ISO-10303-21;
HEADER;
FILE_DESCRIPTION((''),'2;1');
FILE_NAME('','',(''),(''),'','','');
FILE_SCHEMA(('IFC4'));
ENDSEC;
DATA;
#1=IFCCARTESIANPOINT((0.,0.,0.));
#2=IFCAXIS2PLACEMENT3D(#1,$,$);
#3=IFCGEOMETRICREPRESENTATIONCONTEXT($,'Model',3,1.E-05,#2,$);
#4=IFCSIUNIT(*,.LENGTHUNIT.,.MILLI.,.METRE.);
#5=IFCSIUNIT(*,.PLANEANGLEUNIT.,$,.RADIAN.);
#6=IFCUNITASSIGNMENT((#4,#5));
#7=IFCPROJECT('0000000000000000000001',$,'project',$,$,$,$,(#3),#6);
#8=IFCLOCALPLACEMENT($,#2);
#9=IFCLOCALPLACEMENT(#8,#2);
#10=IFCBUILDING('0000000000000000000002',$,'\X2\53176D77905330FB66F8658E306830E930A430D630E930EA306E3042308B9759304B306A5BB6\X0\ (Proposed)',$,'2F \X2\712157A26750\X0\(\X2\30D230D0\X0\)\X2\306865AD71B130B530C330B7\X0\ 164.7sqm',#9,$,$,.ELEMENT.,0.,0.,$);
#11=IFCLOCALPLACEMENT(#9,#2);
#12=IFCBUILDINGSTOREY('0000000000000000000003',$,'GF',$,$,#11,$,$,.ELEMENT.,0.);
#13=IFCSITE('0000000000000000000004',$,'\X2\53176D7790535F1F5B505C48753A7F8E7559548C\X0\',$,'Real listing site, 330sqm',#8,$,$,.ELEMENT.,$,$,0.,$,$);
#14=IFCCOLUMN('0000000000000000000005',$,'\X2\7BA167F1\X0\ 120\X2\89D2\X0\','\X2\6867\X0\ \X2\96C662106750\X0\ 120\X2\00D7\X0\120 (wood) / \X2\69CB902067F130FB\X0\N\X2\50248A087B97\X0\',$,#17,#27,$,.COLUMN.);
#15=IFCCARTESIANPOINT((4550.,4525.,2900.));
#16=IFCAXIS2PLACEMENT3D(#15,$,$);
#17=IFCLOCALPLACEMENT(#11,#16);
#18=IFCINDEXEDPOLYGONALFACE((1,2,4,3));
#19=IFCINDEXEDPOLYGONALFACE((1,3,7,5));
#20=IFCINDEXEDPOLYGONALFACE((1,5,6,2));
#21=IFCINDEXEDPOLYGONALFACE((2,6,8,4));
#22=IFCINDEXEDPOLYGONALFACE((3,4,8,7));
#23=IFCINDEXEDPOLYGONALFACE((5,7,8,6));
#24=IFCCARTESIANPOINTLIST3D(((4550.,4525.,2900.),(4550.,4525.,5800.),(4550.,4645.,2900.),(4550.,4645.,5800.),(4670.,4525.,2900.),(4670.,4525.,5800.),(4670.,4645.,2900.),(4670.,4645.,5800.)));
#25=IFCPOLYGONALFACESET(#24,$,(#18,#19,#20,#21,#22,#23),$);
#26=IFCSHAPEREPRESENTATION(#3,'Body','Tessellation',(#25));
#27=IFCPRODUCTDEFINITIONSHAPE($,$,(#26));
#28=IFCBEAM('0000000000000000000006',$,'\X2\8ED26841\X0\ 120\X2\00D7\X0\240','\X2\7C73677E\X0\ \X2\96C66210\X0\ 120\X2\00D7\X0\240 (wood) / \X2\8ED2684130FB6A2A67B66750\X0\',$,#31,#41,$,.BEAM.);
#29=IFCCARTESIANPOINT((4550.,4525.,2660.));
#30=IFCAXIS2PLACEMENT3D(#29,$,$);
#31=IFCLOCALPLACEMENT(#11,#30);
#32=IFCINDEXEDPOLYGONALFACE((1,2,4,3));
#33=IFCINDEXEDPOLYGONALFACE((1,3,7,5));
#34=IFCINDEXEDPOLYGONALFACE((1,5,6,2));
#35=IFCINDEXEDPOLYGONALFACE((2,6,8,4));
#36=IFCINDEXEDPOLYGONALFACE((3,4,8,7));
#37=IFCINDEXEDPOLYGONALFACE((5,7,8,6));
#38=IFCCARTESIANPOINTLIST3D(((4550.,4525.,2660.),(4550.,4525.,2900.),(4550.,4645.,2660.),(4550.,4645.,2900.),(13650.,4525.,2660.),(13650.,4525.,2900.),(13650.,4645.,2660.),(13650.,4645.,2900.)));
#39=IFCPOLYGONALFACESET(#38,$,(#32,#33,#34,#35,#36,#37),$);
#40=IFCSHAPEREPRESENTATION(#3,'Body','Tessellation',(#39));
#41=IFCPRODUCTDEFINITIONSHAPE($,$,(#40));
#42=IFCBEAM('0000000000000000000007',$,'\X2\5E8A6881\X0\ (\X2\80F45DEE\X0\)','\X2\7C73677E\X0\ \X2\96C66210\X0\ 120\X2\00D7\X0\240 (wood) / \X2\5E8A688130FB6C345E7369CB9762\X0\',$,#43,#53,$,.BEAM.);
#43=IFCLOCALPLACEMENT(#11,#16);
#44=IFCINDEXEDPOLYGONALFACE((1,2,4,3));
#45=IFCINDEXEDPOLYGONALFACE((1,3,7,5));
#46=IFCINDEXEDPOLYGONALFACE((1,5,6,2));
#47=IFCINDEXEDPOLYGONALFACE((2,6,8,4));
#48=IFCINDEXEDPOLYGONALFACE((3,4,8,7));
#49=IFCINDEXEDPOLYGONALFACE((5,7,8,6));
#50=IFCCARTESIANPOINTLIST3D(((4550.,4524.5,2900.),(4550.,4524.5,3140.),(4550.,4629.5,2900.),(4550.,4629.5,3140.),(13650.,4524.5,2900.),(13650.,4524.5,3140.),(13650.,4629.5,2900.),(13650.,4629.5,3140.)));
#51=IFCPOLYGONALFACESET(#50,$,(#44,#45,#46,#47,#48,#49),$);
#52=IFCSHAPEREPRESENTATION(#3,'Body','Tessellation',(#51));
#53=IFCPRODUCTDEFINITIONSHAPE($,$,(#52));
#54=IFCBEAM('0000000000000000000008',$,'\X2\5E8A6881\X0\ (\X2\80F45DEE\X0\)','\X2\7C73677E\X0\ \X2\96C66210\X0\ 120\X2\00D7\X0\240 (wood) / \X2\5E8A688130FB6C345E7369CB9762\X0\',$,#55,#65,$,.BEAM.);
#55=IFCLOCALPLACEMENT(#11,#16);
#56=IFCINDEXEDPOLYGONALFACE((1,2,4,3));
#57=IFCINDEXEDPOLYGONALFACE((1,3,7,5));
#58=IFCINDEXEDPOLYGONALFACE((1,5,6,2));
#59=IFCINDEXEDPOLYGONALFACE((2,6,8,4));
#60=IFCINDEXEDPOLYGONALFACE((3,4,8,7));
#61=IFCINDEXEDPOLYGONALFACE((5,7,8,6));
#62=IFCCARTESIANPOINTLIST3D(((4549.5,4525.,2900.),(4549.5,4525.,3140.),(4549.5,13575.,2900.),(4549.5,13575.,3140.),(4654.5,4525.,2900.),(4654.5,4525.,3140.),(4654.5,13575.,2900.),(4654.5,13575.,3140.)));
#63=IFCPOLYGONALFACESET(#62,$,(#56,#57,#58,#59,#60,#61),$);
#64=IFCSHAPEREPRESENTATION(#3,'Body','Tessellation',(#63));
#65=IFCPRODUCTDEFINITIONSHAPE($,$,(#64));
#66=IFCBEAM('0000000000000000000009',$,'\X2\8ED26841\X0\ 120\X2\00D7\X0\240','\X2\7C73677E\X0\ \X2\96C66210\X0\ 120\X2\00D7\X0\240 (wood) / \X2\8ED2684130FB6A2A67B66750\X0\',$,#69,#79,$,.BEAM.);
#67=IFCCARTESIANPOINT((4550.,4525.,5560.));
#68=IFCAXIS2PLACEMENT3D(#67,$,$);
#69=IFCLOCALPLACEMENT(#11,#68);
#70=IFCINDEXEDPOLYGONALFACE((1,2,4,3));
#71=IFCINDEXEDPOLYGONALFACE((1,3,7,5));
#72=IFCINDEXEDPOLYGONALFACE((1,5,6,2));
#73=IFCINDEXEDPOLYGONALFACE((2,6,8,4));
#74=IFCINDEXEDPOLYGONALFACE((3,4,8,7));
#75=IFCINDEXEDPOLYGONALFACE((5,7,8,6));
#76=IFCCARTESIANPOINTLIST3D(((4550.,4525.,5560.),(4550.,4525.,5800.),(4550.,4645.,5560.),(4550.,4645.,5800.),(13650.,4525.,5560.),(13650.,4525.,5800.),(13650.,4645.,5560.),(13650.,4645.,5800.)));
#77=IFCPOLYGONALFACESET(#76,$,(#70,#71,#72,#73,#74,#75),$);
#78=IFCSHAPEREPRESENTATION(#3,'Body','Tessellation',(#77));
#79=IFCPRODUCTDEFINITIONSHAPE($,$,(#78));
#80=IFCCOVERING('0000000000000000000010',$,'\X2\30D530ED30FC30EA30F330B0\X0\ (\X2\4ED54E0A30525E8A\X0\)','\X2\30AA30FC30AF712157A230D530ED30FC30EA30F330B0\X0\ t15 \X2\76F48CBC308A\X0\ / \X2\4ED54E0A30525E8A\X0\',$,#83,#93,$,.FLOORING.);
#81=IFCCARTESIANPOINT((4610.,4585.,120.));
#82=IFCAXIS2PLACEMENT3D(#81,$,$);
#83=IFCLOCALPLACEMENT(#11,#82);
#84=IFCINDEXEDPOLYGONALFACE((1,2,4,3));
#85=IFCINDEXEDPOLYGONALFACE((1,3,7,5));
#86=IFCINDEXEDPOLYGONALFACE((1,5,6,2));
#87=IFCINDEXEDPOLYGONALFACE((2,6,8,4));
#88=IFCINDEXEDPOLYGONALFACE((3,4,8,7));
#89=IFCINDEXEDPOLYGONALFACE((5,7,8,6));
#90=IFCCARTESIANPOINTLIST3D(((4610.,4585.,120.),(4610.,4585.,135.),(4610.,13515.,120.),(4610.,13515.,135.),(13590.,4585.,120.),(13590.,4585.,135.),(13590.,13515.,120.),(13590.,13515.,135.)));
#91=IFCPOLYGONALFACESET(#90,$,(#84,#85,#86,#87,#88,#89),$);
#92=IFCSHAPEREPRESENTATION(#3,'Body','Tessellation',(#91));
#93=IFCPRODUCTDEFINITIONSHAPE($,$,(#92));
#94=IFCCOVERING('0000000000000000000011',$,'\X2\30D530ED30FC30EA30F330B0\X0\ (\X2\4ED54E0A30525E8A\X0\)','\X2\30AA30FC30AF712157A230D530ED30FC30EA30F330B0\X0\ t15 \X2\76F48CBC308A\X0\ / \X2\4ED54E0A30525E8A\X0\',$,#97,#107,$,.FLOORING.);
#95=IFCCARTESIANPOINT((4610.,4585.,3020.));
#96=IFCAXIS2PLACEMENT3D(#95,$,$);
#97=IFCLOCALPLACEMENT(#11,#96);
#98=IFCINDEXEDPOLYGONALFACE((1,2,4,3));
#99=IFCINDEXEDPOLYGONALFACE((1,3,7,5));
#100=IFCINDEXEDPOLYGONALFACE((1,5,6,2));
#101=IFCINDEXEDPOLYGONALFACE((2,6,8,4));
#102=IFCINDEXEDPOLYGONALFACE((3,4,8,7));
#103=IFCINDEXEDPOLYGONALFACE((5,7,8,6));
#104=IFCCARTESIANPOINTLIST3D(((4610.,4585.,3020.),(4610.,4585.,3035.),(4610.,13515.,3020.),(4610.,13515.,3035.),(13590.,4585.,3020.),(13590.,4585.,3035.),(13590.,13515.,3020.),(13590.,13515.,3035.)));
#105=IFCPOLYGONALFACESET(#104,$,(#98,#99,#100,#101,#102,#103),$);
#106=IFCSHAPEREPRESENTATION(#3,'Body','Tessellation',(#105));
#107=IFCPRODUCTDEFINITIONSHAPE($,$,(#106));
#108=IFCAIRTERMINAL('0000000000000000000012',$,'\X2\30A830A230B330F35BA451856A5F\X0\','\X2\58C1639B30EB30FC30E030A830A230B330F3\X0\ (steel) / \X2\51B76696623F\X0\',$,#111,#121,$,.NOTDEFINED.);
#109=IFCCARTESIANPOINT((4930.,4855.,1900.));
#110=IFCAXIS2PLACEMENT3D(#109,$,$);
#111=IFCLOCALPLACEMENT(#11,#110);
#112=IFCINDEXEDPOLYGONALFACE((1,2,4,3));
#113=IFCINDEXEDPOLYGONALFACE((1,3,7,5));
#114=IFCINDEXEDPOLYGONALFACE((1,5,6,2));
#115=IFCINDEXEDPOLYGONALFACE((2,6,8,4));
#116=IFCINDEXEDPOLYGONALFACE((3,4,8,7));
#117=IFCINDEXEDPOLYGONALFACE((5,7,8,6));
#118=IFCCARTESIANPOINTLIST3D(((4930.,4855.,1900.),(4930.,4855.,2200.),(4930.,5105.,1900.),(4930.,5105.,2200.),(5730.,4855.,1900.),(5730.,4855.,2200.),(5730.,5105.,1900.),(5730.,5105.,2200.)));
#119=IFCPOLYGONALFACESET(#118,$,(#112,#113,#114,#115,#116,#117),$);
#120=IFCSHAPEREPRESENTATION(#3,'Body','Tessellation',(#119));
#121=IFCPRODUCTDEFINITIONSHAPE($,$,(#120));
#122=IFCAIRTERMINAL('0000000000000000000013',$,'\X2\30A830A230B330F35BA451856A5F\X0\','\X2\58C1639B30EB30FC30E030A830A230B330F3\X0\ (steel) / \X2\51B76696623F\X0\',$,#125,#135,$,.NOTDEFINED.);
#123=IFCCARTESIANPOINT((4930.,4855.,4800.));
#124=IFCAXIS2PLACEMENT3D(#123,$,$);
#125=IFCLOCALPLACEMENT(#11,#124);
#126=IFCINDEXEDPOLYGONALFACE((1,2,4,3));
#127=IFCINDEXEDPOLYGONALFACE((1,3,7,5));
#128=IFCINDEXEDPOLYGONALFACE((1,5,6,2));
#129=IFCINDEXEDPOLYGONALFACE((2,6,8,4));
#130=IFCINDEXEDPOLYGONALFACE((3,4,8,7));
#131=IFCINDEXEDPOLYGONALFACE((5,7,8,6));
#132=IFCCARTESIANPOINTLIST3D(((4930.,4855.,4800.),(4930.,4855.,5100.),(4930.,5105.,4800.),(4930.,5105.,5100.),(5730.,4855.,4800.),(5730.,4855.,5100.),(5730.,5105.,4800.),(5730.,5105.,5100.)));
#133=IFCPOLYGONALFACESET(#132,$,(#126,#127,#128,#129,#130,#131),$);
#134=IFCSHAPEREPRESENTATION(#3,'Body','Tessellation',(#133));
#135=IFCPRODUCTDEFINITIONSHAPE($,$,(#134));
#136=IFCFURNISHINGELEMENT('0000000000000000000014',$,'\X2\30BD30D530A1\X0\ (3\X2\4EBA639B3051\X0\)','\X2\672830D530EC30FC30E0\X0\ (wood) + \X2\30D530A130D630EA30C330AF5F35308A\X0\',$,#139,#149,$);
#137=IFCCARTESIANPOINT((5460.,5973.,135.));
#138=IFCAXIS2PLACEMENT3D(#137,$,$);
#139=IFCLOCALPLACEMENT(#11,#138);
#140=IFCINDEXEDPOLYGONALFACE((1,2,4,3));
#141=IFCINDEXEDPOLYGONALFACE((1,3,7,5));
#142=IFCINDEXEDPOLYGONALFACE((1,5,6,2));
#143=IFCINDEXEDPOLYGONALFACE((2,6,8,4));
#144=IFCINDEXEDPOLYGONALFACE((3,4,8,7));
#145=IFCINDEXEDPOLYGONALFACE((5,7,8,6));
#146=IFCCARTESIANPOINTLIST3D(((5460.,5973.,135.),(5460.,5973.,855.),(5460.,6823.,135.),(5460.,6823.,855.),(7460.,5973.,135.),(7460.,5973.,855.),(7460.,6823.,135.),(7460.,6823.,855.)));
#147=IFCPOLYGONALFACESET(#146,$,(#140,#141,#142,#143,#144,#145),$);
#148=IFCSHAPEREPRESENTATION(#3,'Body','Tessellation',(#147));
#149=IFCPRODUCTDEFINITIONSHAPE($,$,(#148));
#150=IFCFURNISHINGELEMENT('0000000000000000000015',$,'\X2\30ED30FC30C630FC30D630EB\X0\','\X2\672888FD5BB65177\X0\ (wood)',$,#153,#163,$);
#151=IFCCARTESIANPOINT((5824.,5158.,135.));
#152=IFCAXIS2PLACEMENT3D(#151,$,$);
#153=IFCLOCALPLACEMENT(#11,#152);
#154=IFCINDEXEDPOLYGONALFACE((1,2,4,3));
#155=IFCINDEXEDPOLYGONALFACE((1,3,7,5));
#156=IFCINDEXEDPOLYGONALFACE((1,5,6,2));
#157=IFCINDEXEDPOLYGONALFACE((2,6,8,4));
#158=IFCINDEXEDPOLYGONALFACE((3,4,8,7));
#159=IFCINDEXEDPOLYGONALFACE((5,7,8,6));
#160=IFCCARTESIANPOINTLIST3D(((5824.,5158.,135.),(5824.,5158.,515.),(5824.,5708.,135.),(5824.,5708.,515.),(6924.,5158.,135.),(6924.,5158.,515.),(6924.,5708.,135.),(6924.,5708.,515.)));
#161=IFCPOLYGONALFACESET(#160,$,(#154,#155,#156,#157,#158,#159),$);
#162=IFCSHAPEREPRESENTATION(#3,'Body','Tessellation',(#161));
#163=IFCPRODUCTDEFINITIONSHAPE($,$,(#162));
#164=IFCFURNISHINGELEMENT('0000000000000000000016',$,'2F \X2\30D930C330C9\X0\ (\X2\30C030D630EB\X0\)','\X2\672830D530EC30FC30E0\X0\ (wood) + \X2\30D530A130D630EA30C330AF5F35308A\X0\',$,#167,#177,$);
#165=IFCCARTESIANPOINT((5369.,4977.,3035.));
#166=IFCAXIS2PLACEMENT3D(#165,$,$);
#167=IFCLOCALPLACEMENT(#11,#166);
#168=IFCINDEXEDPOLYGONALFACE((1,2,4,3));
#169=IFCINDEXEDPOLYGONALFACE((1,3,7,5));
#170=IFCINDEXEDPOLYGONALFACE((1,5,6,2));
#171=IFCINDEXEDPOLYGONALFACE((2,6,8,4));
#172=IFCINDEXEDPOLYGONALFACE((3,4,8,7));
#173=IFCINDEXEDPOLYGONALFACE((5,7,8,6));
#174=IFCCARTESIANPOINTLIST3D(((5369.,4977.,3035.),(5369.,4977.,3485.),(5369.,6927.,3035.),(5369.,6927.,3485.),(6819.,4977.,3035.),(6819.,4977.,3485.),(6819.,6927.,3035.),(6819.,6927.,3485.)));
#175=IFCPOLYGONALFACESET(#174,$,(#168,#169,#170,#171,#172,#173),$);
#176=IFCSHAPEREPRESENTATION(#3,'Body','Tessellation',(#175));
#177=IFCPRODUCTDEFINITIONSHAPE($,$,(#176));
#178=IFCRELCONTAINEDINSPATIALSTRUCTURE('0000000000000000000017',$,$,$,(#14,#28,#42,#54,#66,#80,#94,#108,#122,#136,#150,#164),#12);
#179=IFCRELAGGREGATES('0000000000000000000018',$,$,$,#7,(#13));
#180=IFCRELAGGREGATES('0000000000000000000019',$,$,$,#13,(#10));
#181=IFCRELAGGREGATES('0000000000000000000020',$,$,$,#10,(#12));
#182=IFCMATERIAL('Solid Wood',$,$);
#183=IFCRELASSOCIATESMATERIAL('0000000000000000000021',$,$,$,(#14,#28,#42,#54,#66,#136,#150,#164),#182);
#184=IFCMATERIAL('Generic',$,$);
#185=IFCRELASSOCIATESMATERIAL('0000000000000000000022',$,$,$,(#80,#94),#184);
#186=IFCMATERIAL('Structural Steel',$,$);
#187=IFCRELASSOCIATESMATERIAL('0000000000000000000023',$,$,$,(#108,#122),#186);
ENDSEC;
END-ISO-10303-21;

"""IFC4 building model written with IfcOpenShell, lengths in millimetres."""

from ifc_helpers import new_model, si_unit, frame, frame_2d, origin, place, context, project, spatial, rectangle, extrude, material, element, save


model = new_model("IFC4")

# Units and contexts
model_context = context("Model", 3, precision=1e-05, world=origin())
ifc_project = project(units=[si_unit("LENGTHUNIT", "METRE", prefix="MILLI"), si_unit("PLANEANGLEUNIT", "RADIAN")], contexts=[model_context])

# Site, building, storey
site_placement = place(None, origin())
site = spatial("IfcSite", under=ifc_project, at=site_placement, Name="北海道弟子屈町美留和", ObjectType="Real listing site, 330sqm", CompositionType="ELEMENT", RefElevation=0.0)
building_placement = place(site_placement, origin())
building = spatial("IfcBuilding", under=site, at=building_placement, Name="北海道・書斎とライブラリのある静かな家 (Proposed)", ObjectType="2F 無垢材(ヒバ)と断熱サッシ 164.7sqm", CompositionType="ELEMENT", ElevationOfRefHeight=0.0, ElevationOfTerrain=0.0)
storey_placement = place(building_placement, origin())
storey = spatial("IfcBuildingStorey", under=building, at=storey_placement, Name="GF", CompositionType="ELEMENT", Elevation=0.0)

# Column
ifc_material_1 = material(Name="Solid Wood")
column_1_placement = place(storey_placement, frame((4550.0, 4525.0, 2900.0)))
element("IfcColumn", 1, at=column_1_placement, inside=storey, material=ifc_material_1, Name="管柱 120角", Description="桧 集成材 120×120 (wood) / 構造柱・N値計算", PredefinedType="COLUMN", context=model_context, shape_type="SweptSolid", body=[
    extrude(rectangle(XDim=120.0, YDim=120.0, at=frame_2d((60.0, 60.0))), frame((4550.0, 4525.0, 2900.0)), (0.0, 0.0, 1.0), 2900.0),
])

# Beams
beam_1_placement = place(storey_placement, frame((4550.0, 4525.0, 2660.0)))
element("IfcBeam", 2, at=beam_1_placement, inside=storey, material=ifc_material_1, Name="軒桁 120×240", Description="米松 集成 120×240 (wood) / 軒桁・横架材", PredefinedType="BEAM", context=model_context, shape_type="SweptSolid", body=[
    extrude(rectangle(XDim=9100.0, YDim=120.0, at=frame_2d((4550.0, 60.0))), frame((4550.0, 4525.0, 2660.0)), (0.0, 0.0, 1.0), 240.0),
])
beam_2_placement = place(storey_placement, frame((4550.0, 4525.0, 2900.0)))
element("IfcBeam", 3, at=beam_2_placement, inside=storey, material=ifc_material_1, Name="床梁 (胴差)", Description="米松 集成 120×240 (wood) / 床梁・水平構面", PredefinedType="BEAM", context=model_context, shape_type="SweptSolid", body=[
    extrude(rectangle(XDim=9100.0, YDim=105.0, at=frame_2d((4550.0, 52.0))), frame((4550.0, 4525.0, 2900.0)), (0.0, 0.0, 1.0), 240.0),
])
beam_3_placement = place(storey_placement, frame((4550.0, 4525.0, 2900.0)))
element("IfcBeam", 4, at=beam_3_placement, inside=storey, material=ifc_material_1, Name="床梁 (胴差)", Description="米松 集成 120×240 (wood) / 床梁・水平構面", PredefinedType="BEAM", context=model_context, shape_type="SweptSolid", body=[
    extrude(rectangle(XDim=105.0, YDim=9050.0, at=frame_2d((52.0, 4525.0))), frame((4550.0, 4525.0, 2900.0)), (0.0, 0.0, 1.0), 240.0),
])
beam_4_placement = place(storey_placement, frame((4550.0, 4525.0, 5560.0)))
element("IfcBeam", 5, at=beam_4_placement, inside=storey, material=ifc_material_1, Name="軒桁 120×240", Description="米松 集成 120×240 (wood) / 軒桁・横架材", PredefinedType="BEAM", context=model_context, shape_type="SweptSolid", body=[
    extrude(rectangle(XDim=9100.0, YDim=120.0, at=frame_2d((4550.0, 60.0))), frame((4550.0, 4525.0, 5560.0)), (0.0, 0.0, 1.0), 240.0),
])

# Coverings
ifc_material_2 = material(Name="Generic")
covering_1_placement = place(storey_placement, frame((4610.0, 4585.0, 120.0)))
element("IfcCovering", 6, at=covering_1_placement, inside=storey, material=ifc_material_2, Name="フローリング (仕上げ床)", Description="オーク無垢フローリング t15 直貼り / 仕上げ床", PredefinedType="FLOORING", context=model_context, shape_type="SweptSolid", body=[
    extrude(rectangle(XDim=8980.0, YDim=8930.0, at=frame_2d((4490.0, 4465.0))), frame((4610.0, 4585.0, 120.0)), (0.0, 0.0, 1.0), 15.0),
])
covering_2_placement = place(storey_placement, frame((4610.0, 4585.0, 3020.0)))
element("IfcCovering", 7, at=covering_2_placement, inside=storey, material=ifc_material_2, Name="フローリング (仕上げ床)", Description="オーク無垢フローリング t15 直貼り / 仕上げ床", PredefinedType="FLOORING", context=model_context, shape_type="SweptSolid", body=[
    extrude(rectangle(XDim=8980.0, YDim=8930.0, at=frame_2d((4490.0, 4465.0))), frame((4610.0, 4585.0, 3020.0)), (0.0, 0.0, 1.0), 15.0),
])

# Air terminals
ifc_material_3 = material(Name="Structural Steel")
air_terminal_1_placement = place(storey_placement, frame((4930.0, 4855.0, 1900.0)))
element("IfcAirTerminal", 8, at=air_terminal_1_placement, inside=storey, material=ifc_material_3, Name="エアコン室内機", Description="壁掛ルームエアコン (steel) / 冷暖房", PredefinedType="NOTDEFINED", context=model_context, shape_type="SweptSolid", body=[
    extrude(rectangle(XDim=800.0, YDim=250.0, at=frame_2d((400.0, 125.0))), frame((4930.0, 4855.0, 1900.0)), (0.0, 0.0, 1.0), 300.0),
])
air_terminal_2_placement = place(storey_placement, frame((4930.0, 4855.0, 4800.0)))
element("IfcAirTerminal", 9, at=air_terminal_2_placement, inside=storey, material=ifc_material_3, Name="エアコン室内機", Description="壁掛ルームエアコン (steel) / 冷暖房", PredefinedType="NOTDEFINED", context=model_context, shape_type="SweptSolid", body=[
    extrude(rectangle(XDim=800.0, YDim=250.0, at=frame_2d((400.0, 125.0))), frame((4930.0, 4855.0, 4800.0)), (0.0, 0.0, 1.0), 300.0),
])

# Furnishing elements
furnishing_1_placement = place(storey_placement, frame((5460.0, 5973.0, 135.0)))
element("IfcFurnishingElement", 10, at=furnishing_1_placement, inside=storey, material=ifc_material_1, Name="ソファ (3人掛け)", Description="木フレーム (wood) + ファブリック張り", context=model_context, shape_type="SweptSolid", body=[
    extrude(rectangle(XDim=2000.0, YDim=850.0, at=frame_2d((1000.0, 425.0))), frame((5460.0, 5973.0, 135.0)), (0.0, 0.0, 1.0), 720.0),
])
furnishing_2_placement = place(storey_placement, frame((5824.0, 5158.0, 135.0)))
element("IfcFurnishingElement", 11, at=furnishing_2_placement, inside=storey, material=ifc_material_1, Name="ローテーブル", Description="木製家具 (wood)", context=model_context, shape_type="SweptSolid", body=[
    extrude(rectangle(XDim=1100.0, YDim=550.0, at=frame_2d((550.0, 275.0))), frame((5824.0, 5158.0, 135.0)), (0.0, 0.0, 1.0), 380.0),
])
furnishing_3_placement = place(storey_placement, frame((5369.0, 4977.0, 3035.0)))
element("IfcFurnishingElement", 12, at=furnishing_3_placement, inside=storey, material=ifc_material_1, Name="2F ベッド (ダブル)", Description="木フレーム (wood) + ファブリック張り", context=model_context, shape_type="SweptSolid", body=[
    extrude(rectangle(XDim=1450.0, YDim=1950.0, at=frame_2d((725.0, 975.0))), frame((5369.0, 4977.0, 3035.0)), (0.0, 0.0, 1.0), 450.0),
])

save(model, "model.ifc")
